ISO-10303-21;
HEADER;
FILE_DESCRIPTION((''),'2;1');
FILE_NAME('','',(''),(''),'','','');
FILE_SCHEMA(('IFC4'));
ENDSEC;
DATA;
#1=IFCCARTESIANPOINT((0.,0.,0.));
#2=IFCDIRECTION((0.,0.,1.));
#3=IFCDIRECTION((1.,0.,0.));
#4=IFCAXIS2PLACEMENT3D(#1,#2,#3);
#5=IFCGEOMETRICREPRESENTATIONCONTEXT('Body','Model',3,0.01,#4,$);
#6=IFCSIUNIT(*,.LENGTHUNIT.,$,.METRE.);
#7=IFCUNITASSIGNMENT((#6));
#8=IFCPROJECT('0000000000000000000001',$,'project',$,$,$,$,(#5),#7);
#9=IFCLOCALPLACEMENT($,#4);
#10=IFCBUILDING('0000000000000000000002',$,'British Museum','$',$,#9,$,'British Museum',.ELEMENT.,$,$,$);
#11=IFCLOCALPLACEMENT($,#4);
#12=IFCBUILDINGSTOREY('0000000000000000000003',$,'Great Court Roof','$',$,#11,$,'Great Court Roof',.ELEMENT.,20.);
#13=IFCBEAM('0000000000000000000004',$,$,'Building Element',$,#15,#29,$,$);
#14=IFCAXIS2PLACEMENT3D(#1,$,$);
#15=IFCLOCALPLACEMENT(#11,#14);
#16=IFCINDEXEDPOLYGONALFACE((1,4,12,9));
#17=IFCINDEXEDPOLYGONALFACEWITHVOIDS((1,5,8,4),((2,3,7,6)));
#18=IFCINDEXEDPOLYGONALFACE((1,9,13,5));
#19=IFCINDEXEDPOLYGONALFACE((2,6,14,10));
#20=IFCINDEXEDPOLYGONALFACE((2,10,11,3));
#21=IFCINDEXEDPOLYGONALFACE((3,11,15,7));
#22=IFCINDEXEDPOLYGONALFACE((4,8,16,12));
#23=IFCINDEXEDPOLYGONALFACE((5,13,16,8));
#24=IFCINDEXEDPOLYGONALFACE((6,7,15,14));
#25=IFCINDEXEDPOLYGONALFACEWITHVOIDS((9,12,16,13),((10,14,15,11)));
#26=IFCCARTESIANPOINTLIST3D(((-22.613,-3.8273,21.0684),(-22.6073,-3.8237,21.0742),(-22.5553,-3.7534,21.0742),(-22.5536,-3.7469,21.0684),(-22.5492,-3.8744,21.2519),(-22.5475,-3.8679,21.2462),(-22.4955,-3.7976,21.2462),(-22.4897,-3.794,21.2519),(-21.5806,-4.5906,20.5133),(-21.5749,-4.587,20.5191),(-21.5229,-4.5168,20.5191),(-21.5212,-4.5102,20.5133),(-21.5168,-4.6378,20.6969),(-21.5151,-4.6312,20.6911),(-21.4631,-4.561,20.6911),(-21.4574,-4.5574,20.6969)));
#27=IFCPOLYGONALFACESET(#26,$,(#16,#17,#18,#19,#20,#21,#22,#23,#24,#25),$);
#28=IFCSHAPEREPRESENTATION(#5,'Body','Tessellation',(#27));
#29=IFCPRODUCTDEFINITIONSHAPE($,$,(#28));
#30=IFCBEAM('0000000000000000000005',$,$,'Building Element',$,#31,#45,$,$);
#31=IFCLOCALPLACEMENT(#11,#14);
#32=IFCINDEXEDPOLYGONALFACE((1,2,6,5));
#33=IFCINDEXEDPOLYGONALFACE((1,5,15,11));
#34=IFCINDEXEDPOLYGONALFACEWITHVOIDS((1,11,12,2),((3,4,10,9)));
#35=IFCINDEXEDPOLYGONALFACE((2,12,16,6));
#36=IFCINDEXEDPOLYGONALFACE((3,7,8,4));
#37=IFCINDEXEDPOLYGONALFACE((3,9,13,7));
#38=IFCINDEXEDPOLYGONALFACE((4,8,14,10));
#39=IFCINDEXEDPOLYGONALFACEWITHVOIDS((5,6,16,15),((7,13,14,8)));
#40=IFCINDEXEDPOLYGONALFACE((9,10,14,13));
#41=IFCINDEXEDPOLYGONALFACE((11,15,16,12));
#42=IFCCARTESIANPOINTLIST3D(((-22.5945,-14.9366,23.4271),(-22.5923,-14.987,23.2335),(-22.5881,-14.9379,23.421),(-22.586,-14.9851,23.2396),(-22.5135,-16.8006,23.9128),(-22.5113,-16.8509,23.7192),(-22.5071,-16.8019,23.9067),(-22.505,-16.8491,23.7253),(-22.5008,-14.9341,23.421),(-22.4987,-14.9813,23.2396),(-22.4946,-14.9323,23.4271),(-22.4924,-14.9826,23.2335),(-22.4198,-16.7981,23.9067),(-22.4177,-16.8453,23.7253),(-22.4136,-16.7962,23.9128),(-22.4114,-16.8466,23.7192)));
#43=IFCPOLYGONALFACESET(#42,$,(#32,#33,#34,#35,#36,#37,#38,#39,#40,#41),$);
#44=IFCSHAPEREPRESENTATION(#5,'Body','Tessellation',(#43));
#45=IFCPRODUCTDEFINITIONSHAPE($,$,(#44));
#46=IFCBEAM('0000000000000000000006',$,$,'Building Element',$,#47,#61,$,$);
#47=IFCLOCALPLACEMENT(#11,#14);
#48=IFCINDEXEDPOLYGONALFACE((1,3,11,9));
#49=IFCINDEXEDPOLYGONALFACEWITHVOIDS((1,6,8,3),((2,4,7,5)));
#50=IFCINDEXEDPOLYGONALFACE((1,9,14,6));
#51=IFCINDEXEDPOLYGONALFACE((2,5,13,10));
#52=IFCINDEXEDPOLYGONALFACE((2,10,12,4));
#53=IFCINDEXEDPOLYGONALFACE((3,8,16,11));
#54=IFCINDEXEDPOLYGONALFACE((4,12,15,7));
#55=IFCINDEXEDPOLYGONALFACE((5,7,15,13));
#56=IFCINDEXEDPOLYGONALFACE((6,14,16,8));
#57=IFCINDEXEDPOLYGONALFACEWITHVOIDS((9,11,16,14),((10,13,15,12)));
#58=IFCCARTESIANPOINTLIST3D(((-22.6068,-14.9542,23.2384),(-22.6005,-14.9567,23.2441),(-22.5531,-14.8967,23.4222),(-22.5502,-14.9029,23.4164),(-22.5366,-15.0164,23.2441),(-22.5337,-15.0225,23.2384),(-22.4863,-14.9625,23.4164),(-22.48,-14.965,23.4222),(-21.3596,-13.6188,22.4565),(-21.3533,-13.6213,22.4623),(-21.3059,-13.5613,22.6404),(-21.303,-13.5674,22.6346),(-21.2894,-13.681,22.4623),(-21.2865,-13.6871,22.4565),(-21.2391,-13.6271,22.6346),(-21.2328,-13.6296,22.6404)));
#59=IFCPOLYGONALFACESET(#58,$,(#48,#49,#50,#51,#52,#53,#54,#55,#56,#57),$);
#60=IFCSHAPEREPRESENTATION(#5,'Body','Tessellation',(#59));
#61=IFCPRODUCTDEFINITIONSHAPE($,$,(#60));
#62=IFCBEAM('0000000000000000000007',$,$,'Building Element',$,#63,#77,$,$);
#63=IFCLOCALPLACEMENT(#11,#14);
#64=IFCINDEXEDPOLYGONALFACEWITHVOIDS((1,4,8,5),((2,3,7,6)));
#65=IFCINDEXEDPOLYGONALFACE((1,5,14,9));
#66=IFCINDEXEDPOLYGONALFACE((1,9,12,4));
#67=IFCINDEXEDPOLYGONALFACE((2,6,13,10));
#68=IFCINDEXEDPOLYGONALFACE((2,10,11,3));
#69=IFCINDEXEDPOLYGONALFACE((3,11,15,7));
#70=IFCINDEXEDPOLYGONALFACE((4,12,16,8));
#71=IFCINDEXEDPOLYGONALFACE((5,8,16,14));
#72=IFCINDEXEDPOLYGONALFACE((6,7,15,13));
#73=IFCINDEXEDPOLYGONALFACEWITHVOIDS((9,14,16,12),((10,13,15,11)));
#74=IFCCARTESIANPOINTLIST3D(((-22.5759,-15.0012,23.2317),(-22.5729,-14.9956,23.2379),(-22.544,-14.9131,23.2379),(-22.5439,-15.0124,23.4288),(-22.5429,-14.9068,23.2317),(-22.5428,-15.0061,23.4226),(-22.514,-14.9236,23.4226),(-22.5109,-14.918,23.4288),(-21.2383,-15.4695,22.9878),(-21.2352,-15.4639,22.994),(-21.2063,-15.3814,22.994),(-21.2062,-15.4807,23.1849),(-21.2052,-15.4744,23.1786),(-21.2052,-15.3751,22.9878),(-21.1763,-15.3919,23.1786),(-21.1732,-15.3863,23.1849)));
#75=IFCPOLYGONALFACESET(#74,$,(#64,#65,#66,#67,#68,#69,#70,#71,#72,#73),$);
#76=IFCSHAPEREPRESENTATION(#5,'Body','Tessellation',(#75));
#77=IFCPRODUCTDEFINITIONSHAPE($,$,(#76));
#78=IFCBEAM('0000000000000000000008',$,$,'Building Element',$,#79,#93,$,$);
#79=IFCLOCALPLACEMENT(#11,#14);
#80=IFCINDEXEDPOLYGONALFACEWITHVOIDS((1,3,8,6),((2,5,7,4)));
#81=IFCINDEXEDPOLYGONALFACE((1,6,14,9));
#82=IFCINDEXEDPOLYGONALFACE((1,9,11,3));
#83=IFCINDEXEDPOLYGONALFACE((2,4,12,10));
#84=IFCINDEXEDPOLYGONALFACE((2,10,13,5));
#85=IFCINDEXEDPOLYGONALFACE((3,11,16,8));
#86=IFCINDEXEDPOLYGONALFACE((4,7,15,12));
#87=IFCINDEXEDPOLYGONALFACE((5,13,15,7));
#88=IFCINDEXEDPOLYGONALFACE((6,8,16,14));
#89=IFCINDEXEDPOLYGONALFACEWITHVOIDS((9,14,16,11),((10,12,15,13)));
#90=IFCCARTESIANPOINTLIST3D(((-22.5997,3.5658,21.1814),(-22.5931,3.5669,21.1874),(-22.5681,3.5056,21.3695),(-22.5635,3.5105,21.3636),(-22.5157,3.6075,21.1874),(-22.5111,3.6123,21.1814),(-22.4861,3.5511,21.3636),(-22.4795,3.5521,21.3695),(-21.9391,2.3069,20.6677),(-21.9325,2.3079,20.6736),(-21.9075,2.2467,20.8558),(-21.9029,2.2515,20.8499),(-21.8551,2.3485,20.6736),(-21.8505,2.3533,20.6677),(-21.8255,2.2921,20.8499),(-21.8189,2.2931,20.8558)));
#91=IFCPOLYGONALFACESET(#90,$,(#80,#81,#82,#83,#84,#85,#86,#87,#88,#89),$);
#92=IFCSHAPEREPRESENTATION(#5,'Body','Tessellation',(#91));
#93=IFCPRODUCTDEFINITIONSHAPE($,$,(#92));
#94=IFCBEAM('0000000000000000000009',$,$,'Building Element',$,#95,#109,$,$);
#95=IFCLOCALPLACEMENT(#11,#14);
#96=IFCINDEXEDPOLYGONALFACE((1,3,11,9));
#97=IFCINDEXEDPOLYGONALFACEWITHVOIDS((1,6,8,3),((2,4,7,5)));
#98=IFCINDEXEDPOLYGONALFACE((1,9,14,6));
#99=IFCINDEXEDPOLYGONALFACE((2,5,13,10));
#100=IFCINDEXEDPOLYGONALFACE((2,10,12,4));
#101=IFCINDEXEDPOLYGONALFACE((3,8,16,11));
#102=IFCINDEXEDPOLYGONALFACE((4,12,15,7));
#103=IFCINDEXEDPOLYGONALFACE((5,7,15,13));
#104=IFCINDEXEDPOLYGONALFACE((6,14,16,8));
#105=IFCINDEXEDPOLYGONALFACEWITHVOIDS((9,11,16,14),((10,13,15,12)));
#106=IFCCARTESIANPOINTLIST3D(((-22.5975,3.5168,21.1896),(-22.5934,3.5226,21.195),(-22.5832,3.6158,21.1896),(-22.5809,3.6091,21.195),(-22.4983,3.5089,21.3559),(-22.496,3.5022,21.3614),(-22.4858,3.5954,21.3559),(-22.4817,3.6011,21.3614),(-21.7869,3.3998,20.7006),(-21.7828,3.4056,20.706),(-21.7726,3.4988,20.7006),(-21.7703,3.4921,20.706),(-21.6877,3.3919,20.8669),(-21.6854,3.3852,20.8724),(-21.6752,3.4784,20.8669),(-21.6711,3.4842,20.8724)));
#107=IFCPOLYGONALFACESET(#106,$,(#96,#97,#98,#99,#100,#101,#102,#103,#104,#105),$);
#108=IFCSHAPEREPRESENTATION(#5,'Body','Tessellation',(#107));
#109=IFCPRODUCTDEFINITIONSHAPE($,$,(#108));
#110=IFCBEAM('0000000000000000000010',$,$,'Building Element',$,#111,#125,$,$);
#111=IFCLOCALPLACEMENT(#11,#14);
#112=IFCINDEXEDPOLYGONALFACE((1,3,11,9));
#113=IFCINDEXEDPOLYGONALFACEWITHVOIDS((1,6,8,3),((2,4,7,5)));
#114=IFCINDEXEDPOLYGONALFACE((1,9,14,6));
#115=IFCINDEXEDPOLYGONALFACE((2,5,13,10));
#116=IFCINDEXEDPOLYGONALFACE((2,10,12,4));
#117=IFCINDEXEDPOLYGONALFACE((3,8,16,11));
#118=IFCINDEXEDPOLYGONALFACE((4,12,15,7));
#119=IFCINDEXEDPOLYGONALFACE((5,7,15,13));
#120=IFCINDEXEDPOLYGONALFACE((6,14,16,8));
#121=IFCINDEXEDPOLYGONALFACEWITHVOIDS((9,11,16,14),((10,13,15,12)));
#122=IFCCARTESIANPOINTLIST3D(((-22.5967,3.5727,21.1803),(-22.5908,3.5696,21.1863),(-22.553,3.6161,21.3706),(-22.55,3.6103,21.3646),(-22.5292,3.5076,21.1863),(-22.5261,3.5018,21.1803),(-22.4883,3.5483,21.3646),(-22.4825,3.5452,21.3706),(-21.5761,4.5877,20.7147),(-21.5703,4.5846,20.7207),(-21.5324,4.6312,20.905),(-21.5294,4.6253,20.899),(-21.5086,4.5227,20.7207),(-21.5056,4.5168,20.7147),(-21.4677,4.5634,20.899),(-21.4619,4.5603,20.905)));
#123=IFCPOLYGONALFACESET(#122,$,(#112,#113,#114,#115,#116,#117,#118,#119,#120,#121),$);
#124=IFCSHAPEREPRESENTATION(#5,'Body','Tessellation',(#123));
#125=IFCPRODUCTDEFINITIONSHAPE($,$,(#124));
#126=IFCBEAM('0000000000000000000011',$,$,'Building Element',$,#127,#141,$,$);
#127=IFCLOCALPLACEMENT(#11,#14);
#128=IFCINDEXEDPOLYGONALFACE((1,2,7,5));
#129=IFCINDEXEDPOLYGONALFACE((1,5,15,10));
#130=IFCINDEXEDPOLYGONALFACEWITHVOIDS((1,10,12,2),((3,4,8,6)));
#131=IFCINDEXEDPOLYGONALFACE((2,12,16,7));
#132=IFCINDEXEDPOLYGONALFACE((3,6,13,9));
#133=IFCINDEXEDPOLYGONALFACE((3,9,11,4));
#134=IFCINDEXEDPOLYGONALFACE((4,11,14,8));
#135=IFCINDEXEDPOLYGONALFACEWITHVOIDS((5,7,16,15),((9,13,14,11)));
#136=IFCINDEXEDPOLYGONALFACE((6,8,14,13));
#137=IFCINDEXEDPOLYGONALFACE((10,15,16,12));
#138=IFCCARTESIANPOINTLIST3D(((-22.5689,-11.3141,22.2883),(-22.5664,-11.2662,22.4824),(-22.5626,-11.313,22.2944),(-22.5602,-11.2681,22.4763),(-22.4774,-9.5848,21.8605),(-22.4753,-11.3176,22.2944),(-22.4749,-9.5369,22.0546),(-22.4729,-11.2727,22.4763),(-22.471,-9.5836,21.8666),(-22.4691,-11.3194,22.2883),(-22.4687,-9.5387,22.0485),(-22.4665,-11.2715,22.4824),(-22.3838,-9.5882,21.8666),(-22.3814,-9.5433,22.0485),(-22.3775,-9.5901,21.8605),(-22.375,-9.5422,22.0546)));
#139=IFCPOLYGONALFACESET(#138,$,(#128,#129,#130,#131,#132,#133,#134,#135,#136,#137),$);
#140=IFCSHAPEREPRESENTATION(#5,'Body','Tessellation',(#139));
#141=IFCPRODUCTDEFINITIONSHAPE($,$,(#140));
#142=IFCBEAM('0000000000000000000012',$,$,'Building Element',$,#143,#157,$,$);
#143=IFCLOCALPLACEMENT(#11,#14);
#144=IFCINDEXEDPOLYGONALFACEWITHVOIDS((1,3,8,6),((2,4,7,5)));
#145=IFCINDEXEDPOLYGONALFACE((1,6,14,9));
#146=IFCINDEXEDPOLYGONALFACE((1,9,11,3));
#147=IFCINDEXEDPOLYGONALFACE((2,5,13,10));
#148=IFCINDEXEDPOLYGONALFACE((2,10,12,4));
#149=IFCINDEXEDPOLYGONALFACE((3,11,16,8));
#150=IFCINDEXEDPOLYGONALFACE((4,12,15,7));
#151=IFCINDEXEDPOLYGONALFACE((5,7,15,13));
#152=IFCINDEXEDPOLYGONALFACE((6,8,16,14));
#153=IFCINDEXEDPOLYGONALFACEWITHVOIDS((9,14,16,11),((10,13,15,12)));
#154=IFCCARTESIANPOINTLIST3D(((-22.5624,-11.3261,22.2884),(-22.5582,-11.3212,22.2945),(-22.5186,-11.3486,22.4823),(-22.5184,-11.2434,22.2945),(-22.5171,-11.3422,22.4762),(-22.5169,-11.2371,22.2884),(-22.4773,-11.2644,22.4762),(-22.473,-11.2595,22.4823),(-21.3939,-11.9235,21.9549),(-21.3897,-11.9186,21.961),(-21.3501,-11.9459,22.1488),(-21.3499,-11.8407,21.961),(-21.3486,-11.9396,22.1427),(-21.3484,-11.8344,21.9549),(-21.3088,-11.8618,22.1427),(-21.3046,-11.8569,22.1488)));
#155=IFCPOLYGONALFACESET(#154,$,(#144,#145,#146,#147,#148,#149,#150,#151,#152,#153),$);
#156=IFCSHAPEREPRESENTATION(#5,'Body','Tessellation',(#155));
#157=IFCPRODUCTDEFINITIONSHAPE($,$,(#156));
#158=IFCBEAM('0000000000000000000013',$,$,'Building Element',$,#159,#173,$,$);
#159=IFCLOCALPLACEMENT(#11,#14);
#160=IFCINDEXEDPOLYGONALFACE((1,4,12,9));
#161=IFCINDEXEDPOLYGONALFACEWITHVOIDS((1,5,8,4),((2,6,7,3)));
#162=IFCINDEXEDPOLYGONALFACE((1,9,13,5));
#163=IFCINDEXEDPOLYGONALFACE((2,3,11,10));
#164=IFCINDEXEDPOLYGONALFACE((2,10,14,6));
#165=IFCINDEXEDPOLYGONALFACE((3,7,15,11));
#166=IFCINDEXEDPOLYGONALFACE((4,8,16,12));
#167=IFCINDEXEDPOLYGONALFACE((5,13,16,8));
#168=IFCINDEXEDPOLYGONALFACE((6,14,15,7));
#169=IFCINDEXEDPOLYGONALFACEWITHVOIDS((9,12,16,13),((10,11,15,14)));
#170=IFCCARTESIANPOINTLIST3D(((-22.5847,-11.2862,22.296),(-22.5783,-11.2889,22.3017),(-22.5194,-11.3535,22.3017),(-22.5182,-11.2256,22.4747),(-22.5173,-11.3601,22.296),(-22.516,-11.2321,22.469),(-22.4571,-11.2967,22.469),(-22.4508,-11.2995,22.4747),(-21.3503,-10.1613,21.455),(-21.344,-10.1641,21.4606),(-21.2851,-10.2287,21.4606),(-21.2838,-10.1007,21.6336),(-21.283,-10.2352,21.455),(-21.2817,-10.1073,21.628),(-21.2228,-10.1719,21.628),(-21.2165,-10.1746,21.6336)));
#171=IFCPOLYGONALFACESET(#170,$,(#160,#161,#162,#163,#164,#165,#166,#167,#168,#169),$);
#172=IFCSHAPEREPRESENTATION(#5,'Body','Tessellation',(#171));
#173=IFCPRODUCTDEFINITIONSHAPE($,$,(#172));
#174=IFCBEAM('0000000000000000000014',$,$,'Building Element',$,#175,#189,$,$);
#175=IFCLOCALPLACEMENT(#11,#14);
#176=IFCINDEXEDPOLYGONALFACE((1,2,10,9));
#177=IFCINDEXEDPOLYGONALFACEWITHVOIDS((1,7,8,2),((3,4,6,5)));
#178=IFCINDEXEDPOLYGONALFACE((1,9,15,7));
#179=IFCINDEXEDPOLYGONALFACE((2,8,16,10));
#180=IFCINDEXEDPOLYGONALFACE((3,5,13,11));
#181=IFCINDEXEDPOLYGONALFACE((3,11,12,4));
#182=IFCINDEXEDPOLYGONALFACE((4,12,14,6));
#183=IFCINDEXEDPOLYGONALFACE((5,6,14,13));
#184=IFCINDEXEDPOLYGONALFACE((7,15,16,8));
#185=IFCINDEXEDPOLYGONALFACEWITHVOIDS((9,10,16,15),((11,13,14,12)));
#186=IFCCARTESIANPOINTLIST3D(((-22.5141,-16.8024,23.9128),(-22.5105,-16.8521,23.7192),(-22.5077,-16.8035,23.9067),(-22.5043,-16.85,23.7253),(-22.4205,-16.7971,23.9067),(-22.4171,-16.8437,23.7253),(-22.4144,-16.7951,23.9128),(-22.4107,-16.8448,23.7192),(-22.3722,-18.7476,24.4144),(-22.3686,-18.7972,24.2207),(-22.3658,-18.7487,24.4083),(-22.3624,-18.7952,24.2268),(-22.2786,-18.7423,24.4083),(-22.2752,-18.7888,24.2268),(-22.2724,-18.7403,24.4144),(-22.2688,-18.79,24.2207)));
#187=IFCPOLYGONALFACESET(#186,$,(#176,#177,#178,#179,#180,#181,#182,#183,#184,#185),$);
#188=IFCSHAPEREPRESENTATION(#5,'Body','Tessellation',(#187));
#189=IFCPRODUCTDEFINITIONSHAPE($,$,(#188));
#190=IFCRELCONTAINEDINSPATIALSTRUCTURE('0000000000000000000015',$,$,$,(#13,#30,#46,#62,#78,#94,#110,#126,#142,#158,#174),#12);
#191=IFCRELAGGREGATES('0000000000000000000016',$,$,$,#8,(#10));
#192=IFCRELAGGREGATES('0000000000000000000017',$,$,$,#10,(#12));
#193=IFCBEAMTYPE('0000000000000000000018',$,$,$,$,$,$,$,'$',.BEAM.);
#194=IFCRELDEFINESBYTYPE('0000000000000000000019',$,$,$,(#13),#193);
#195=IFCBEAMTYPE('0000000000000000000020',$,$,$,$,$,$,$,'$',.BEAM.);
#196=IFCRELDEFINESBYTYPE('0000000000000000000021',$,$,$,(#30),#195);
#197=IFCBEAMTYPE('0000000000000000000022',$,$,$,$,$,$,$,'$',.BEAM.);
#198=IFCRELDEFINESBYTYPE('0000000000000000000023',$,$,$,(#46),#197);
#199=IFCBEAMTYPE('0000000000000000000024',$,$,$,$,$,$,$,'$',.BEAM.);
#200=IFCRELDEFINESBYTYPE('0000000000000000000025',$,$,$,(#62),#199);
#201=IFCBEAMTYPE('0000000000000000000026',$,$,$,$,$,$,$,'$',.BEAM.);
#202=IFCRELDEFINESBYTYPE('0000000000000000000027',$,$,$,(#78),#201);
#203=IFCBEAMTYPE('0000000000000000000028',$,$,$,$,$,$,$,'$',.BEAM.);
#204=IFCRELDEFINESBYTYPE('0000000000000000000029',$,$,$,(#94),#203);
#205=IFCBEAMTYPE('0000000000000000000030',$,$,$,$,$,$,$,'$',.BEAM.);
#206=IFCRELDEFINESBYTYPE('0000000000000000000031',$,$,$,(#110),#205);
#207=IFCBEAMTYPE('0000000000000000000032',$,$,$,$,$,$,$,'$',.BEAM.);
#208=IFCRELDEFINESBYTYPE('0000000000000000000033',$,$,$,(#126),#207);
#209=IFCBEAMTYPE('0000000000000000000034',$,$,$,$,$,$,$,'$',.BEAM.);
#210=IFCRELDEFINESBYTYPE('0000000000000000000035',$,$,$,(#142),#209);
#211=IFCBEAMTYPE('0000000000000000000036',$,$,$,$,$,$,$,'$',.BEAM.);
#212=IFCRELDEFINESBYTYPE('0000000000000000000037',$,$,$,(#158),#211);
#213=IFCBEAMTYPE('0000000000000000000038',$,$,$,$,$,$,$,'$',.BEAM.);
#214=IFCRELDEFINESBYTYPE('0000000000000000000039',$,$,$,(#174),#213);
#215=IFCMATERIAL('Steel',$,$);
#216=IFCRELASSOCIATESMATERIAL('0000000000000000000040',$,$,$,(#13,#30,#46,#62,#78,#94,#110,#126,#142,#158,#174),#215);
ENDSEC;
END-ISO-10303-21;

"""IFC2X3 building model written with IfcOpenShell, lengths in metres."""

from ifc_helpers import new_model, si_unit, frame, origin_with_axes, origin_2d, place, context, project, spatial, hollow_rectangle, extrude, material, type_object, element, save


model = new_model("IFC2X3")

# Units and contexts
model_context = context("Model", 3, precision=0.01, world=origin_with_axes(), identifier="Body")
ifc_project = project(units=[si_unit("LENGTHUNIT", "METRE")], contexts=[model_context])

# Building, storey
building_placement = place(None, origin_with_axes())
building = spatial("IfcBuilding", under=ifc_project, at=building_placement, Name="British Museum", Description="$", LongName="British Museum", CompositionType="ELEMENT")
storey_placement = place(None, origin_with_axes())
storey = spatial("IfcBuildingStorey", under=building, at=storey_placement, Name="Great Court Roof", Description="$", LongName="Great Court Roof", CompositionType="ELEMENT", Elevation=20.0)

# Beams
ifc_material = material(Name="Steel")
beam_type_1 = type_object("IfcBeamType", ElementType="$", PredefinedType="BEAM")
beam_1_placement = place(None, origin_with_axes())
element("IfcBeam", 1, at=beam_1_placement, inside=storey, type_object=beam_type_1, material=ifc_material, Description="Building Element", context=model_context, shape_type="SweptSolid", body=[
    extrude(hollow_rectangle(XDim=0.1, YDim=0.2, WallThickness=0.0063, InnerFilletRadius=-0.0063, OuterFilletRadius=0.0, at=origin_2d()), frame((-22.5514, -3.8107, 21.1602), z_axis=(0.738051, -0.545716, -0.39683), x_axis=(0.594532, 0.804072, 0.0)), (0.0, 0.0, 1.0), 1.3988),
])
beam_type_2 = type_object("IfcBeamType", ElementType="$", PredefinedType="BEAM")
beam_2_placement = place(None, origin_with_axes())
element("IfcBeam", 2, at=beam_2_placement, inside=storey, type_object=beam_type_2, material=ifc_material, Description="Building Element", context=model_context, shape_type="SweptSolid", body=[
    extrude(hollow_rectangle(XDim=0.1, YDim=0.2, WallThickness=0.0063, InnerFilletRadius=-0.0063, OuterFilletRadius=0.0, at=origin_2d()), frame((-22.5434, -14.9596, 23.3303), z_axis=(0.042014, -0.966831, 0.251938), x_axis=(0.999057, 0.043414, 0.0)), (0.0, 0.0, 1.0), 1.9279),
])
beam_type_3 = type_object("IfcBeamType", ElementType="$", PredefinedType="BEAM")
beam_3_placement = place(None, origin_with_axes())
element("IfcBeam", 3, at=beam_3_placement, inside=storey, type_object=beam_type_3, material=ifc_material, Description="Building Element", context=model_context, shape_type="SweptSolid", body=[
    extrude(hollow_rectangle(XDim=0.1, YDim=0.2, WallThickness=0.0063, InnerFilletRadius=-0.0063, OuterFilletRadius=0.0, at=origin_2d()), frame((-22.5434, -14.9596, 23.3303), z_axis=(0.62752, 0.671917, -0.393377), x_axis=(-0.730839, 0.682549, 0.0)), (0.0, 0.0, 1.0), 1.9875),
])
beam_type_4 = type_object("IfcBeamType", ElementType="$", PredefinedType="BEAM")
beam_4_placement = place(None, origin_with_axes())
element("IfcBeam", 4, at=beam_4_placement, inside=storey, type_object=beam_type_4, material=ifc_material, Description="Building Element", context=model_context, shape_type="SweptSolid", body=[
    extrude(hollow_rectangle(XDim=0.1, YDim=0.2, WallThickness=0.0063, InnerFilletRadius=-0.0063, OuterFilletRadius=0.0, at=origin_2d()), frame((-22.5434, -14.9596, 23.3303), z_axis=(0.930156, -0.325619, -0.169653), x_axis=(0.330408, 0.943838, 0.0)), (0.0, 0.0, 1.0), 1.4381),
])
beam_type_5 = type_object("IfcBeamType", ElementType="$", PredefinedType="BEAM")
beam_5_placement = place(None, origin_with_axes())
element("IfcBeam", 5, at=beam_5_placement, inside=storey, type_object=beam_type_5, material=ifc_material, Description="Building Element", context=model_context, shape_type="SweptSolid", body=[
    extrude(hollow_rectangle(XDim=0.1, YDim=0.2, WallThickness=0.0063, InnerFilletRadius=-0.0063, OuterFilletRadius=0.0, at=origin_2d()), frame((-22.5396, 3.559, 21.2755), z_axis=(0.436973, -0.832801, -0.339848), x_axis=(0.885506, 0.464628, 0.0)), (0.0, 0.0, 1.0), 1.5117),
])
beam_type_6 = type_object("IfcBeamType", ElementType="$", PredefinedType="BEAM")
beam_6_placement = place(None, origin_with_axes())
element("IfcBeam", 6, at=beam_6_placement, inside=storey, type_object=beam_type_6, material=ifc_material, Description="Building Element", context=model_context, shape_type="SweptSolid", body=[
    extrude(hollow_rectangle(XDim=0.1, YDim=0.2, WallThickness=0.0063, InnerFilletRadius=-0.0063, OuterFilletRadius=0.0, at=origin_2d()), frame((-22.5396, 3.559, 21.2755), z_axis=(0.849795, -0.122627, -0.512651), x_axis=(0.142823, 0.989748, 0.0)), (0.0, 0.0, 1.0), 0.9539),
])
beam_type_7 = type_object("IfcBeamType", ElementType="$", PredefinedType="BEAM")
beam_7_placement = place(None, origin_with_axes())
element("IfcBeam", 7, at=beam_7_placement, inside=storey, type_object=beam_type_7, material=ifc_material, Description="Building Element", context=model_context, shape_type="SweptSolid", body=[
    extrude(hollow_rectangle(XDim=0.1, YDim=0.2, WallThickness=0.0063, InnerFilletRadius=-0.0063, OuterFilletRadius=0.0, at=origin_2d()), frame((-22.5396, 3.559, 21.2755), z_axis=(0.674617, 0.670945, -0.307775), x_axis=(-0.705175, 0.709034, 0.0)), (0.0, 0.0, 1.0), 1.5128),
])
beam_type_8 = type_object("IfcBeamType", ElementType="$", PredefinedType="BEAM")
beam_8_placement = place(None, origin_with_axes())
element("IfcBeam", 8, at=beam_8_placement, inside=storey, type_object=beam_type_8, material=ifc_material, Description="Building Element", context=model_context, shape_type="SweptSolid", body=[
    extrude(hollow_rectangle(XDim=0.1, YDim=0.2, WallThickness=0.0063, InnerFilletRadius=-0.0063, OuterFilletRadius=0.0, at=origin_2d()), frame((-22.5177, -11.2928, 22.3854), z_axis=(0.051306, 0.969459, -0.239826), x_axis=(-0.998603, 0.052848, 0.0)), (0.0, 0.0, 1.0), 1.7838),
])
beam_type_9 = type_object("IfcBeamType", ElementType="$", PredefinedType="BEAM")
beam_9_placement = place(None, origin_with_axes())
element("IfcBeam", 9, at=beam_9_placement, inside=storey, type_object=beam_type_9, material=ifc_material, Description="Building Element", context=model_context, shape_type="SweptSolid", body=[
    extrude(hollow_rectangle(XDim=0.1, YDim=0.2, WallThickness=0.0063, InnerFilletRadius=-0.0063, OuterFilletRadius=0.0, at=origin_2d()), frame((-22.5177, -11.2928, 22.3854), z_axis=(0.862969, -0.441156, -0.246304), x_axis=(0.455179, 0.8904, 0.0)), (0.0, 0.0, 1.0), 1.354),
])
beam_type_10 = type_object("IfcBeamType", ElementType="$", PredefinedType="BEAM")
beam_10_placement = place(None, origin_with_axes())
element("IfcBeam", 10, at=beam_10_placement, inside=storey, type_object=beam_type_10, material=ifc_material, Description="Building Element", context=model_context, shape_type="SweptSolid", body=[
    extrude(hollow_rectangle(XDim=0.1, YDim=0.2, WallThickness=0.0063, InnerFilletRadius=-0.0063, OuterFilletRadius=0.0, at=origin_2d()), frame((-22.5177, -11.2928, 22.3854), z_axis=(0.660132, 0.601586, -0.4498), x_axis=(-0.673571, 0.739122, 0.0)), (0.0, 0.0, 1.0), 1.8698),
])
beam_type_11 = type_object("IfcBeamType", ElementType="$", PredefinedType="BEAM")
beam_11_placement = place(None, origin_with_axes())
element("IfcBeam", 11, at=beam_11_placement, inside=storey, type_object=beam_type_11, material=ifc_material, Description="Building Element", context=model_context, shape_type="SweptSolid", body=[
    extrude(hollow_rectangle(XDim=0.1, YDim=0.2, WallThickness=0.0063, InnerFilletRadius=-0.0063, OuterFilletRadius=0.0, at=origin_2d()), frame((-22.4624, -16.8236, 23.816), z_axis=(0.07047, -0.965926, 0.249039), x_axis=(0.997349, 0.072763, 0.0)), (0.0, 0.0, 1.0), 2.0138),
])

save(model, "model.ifc")
